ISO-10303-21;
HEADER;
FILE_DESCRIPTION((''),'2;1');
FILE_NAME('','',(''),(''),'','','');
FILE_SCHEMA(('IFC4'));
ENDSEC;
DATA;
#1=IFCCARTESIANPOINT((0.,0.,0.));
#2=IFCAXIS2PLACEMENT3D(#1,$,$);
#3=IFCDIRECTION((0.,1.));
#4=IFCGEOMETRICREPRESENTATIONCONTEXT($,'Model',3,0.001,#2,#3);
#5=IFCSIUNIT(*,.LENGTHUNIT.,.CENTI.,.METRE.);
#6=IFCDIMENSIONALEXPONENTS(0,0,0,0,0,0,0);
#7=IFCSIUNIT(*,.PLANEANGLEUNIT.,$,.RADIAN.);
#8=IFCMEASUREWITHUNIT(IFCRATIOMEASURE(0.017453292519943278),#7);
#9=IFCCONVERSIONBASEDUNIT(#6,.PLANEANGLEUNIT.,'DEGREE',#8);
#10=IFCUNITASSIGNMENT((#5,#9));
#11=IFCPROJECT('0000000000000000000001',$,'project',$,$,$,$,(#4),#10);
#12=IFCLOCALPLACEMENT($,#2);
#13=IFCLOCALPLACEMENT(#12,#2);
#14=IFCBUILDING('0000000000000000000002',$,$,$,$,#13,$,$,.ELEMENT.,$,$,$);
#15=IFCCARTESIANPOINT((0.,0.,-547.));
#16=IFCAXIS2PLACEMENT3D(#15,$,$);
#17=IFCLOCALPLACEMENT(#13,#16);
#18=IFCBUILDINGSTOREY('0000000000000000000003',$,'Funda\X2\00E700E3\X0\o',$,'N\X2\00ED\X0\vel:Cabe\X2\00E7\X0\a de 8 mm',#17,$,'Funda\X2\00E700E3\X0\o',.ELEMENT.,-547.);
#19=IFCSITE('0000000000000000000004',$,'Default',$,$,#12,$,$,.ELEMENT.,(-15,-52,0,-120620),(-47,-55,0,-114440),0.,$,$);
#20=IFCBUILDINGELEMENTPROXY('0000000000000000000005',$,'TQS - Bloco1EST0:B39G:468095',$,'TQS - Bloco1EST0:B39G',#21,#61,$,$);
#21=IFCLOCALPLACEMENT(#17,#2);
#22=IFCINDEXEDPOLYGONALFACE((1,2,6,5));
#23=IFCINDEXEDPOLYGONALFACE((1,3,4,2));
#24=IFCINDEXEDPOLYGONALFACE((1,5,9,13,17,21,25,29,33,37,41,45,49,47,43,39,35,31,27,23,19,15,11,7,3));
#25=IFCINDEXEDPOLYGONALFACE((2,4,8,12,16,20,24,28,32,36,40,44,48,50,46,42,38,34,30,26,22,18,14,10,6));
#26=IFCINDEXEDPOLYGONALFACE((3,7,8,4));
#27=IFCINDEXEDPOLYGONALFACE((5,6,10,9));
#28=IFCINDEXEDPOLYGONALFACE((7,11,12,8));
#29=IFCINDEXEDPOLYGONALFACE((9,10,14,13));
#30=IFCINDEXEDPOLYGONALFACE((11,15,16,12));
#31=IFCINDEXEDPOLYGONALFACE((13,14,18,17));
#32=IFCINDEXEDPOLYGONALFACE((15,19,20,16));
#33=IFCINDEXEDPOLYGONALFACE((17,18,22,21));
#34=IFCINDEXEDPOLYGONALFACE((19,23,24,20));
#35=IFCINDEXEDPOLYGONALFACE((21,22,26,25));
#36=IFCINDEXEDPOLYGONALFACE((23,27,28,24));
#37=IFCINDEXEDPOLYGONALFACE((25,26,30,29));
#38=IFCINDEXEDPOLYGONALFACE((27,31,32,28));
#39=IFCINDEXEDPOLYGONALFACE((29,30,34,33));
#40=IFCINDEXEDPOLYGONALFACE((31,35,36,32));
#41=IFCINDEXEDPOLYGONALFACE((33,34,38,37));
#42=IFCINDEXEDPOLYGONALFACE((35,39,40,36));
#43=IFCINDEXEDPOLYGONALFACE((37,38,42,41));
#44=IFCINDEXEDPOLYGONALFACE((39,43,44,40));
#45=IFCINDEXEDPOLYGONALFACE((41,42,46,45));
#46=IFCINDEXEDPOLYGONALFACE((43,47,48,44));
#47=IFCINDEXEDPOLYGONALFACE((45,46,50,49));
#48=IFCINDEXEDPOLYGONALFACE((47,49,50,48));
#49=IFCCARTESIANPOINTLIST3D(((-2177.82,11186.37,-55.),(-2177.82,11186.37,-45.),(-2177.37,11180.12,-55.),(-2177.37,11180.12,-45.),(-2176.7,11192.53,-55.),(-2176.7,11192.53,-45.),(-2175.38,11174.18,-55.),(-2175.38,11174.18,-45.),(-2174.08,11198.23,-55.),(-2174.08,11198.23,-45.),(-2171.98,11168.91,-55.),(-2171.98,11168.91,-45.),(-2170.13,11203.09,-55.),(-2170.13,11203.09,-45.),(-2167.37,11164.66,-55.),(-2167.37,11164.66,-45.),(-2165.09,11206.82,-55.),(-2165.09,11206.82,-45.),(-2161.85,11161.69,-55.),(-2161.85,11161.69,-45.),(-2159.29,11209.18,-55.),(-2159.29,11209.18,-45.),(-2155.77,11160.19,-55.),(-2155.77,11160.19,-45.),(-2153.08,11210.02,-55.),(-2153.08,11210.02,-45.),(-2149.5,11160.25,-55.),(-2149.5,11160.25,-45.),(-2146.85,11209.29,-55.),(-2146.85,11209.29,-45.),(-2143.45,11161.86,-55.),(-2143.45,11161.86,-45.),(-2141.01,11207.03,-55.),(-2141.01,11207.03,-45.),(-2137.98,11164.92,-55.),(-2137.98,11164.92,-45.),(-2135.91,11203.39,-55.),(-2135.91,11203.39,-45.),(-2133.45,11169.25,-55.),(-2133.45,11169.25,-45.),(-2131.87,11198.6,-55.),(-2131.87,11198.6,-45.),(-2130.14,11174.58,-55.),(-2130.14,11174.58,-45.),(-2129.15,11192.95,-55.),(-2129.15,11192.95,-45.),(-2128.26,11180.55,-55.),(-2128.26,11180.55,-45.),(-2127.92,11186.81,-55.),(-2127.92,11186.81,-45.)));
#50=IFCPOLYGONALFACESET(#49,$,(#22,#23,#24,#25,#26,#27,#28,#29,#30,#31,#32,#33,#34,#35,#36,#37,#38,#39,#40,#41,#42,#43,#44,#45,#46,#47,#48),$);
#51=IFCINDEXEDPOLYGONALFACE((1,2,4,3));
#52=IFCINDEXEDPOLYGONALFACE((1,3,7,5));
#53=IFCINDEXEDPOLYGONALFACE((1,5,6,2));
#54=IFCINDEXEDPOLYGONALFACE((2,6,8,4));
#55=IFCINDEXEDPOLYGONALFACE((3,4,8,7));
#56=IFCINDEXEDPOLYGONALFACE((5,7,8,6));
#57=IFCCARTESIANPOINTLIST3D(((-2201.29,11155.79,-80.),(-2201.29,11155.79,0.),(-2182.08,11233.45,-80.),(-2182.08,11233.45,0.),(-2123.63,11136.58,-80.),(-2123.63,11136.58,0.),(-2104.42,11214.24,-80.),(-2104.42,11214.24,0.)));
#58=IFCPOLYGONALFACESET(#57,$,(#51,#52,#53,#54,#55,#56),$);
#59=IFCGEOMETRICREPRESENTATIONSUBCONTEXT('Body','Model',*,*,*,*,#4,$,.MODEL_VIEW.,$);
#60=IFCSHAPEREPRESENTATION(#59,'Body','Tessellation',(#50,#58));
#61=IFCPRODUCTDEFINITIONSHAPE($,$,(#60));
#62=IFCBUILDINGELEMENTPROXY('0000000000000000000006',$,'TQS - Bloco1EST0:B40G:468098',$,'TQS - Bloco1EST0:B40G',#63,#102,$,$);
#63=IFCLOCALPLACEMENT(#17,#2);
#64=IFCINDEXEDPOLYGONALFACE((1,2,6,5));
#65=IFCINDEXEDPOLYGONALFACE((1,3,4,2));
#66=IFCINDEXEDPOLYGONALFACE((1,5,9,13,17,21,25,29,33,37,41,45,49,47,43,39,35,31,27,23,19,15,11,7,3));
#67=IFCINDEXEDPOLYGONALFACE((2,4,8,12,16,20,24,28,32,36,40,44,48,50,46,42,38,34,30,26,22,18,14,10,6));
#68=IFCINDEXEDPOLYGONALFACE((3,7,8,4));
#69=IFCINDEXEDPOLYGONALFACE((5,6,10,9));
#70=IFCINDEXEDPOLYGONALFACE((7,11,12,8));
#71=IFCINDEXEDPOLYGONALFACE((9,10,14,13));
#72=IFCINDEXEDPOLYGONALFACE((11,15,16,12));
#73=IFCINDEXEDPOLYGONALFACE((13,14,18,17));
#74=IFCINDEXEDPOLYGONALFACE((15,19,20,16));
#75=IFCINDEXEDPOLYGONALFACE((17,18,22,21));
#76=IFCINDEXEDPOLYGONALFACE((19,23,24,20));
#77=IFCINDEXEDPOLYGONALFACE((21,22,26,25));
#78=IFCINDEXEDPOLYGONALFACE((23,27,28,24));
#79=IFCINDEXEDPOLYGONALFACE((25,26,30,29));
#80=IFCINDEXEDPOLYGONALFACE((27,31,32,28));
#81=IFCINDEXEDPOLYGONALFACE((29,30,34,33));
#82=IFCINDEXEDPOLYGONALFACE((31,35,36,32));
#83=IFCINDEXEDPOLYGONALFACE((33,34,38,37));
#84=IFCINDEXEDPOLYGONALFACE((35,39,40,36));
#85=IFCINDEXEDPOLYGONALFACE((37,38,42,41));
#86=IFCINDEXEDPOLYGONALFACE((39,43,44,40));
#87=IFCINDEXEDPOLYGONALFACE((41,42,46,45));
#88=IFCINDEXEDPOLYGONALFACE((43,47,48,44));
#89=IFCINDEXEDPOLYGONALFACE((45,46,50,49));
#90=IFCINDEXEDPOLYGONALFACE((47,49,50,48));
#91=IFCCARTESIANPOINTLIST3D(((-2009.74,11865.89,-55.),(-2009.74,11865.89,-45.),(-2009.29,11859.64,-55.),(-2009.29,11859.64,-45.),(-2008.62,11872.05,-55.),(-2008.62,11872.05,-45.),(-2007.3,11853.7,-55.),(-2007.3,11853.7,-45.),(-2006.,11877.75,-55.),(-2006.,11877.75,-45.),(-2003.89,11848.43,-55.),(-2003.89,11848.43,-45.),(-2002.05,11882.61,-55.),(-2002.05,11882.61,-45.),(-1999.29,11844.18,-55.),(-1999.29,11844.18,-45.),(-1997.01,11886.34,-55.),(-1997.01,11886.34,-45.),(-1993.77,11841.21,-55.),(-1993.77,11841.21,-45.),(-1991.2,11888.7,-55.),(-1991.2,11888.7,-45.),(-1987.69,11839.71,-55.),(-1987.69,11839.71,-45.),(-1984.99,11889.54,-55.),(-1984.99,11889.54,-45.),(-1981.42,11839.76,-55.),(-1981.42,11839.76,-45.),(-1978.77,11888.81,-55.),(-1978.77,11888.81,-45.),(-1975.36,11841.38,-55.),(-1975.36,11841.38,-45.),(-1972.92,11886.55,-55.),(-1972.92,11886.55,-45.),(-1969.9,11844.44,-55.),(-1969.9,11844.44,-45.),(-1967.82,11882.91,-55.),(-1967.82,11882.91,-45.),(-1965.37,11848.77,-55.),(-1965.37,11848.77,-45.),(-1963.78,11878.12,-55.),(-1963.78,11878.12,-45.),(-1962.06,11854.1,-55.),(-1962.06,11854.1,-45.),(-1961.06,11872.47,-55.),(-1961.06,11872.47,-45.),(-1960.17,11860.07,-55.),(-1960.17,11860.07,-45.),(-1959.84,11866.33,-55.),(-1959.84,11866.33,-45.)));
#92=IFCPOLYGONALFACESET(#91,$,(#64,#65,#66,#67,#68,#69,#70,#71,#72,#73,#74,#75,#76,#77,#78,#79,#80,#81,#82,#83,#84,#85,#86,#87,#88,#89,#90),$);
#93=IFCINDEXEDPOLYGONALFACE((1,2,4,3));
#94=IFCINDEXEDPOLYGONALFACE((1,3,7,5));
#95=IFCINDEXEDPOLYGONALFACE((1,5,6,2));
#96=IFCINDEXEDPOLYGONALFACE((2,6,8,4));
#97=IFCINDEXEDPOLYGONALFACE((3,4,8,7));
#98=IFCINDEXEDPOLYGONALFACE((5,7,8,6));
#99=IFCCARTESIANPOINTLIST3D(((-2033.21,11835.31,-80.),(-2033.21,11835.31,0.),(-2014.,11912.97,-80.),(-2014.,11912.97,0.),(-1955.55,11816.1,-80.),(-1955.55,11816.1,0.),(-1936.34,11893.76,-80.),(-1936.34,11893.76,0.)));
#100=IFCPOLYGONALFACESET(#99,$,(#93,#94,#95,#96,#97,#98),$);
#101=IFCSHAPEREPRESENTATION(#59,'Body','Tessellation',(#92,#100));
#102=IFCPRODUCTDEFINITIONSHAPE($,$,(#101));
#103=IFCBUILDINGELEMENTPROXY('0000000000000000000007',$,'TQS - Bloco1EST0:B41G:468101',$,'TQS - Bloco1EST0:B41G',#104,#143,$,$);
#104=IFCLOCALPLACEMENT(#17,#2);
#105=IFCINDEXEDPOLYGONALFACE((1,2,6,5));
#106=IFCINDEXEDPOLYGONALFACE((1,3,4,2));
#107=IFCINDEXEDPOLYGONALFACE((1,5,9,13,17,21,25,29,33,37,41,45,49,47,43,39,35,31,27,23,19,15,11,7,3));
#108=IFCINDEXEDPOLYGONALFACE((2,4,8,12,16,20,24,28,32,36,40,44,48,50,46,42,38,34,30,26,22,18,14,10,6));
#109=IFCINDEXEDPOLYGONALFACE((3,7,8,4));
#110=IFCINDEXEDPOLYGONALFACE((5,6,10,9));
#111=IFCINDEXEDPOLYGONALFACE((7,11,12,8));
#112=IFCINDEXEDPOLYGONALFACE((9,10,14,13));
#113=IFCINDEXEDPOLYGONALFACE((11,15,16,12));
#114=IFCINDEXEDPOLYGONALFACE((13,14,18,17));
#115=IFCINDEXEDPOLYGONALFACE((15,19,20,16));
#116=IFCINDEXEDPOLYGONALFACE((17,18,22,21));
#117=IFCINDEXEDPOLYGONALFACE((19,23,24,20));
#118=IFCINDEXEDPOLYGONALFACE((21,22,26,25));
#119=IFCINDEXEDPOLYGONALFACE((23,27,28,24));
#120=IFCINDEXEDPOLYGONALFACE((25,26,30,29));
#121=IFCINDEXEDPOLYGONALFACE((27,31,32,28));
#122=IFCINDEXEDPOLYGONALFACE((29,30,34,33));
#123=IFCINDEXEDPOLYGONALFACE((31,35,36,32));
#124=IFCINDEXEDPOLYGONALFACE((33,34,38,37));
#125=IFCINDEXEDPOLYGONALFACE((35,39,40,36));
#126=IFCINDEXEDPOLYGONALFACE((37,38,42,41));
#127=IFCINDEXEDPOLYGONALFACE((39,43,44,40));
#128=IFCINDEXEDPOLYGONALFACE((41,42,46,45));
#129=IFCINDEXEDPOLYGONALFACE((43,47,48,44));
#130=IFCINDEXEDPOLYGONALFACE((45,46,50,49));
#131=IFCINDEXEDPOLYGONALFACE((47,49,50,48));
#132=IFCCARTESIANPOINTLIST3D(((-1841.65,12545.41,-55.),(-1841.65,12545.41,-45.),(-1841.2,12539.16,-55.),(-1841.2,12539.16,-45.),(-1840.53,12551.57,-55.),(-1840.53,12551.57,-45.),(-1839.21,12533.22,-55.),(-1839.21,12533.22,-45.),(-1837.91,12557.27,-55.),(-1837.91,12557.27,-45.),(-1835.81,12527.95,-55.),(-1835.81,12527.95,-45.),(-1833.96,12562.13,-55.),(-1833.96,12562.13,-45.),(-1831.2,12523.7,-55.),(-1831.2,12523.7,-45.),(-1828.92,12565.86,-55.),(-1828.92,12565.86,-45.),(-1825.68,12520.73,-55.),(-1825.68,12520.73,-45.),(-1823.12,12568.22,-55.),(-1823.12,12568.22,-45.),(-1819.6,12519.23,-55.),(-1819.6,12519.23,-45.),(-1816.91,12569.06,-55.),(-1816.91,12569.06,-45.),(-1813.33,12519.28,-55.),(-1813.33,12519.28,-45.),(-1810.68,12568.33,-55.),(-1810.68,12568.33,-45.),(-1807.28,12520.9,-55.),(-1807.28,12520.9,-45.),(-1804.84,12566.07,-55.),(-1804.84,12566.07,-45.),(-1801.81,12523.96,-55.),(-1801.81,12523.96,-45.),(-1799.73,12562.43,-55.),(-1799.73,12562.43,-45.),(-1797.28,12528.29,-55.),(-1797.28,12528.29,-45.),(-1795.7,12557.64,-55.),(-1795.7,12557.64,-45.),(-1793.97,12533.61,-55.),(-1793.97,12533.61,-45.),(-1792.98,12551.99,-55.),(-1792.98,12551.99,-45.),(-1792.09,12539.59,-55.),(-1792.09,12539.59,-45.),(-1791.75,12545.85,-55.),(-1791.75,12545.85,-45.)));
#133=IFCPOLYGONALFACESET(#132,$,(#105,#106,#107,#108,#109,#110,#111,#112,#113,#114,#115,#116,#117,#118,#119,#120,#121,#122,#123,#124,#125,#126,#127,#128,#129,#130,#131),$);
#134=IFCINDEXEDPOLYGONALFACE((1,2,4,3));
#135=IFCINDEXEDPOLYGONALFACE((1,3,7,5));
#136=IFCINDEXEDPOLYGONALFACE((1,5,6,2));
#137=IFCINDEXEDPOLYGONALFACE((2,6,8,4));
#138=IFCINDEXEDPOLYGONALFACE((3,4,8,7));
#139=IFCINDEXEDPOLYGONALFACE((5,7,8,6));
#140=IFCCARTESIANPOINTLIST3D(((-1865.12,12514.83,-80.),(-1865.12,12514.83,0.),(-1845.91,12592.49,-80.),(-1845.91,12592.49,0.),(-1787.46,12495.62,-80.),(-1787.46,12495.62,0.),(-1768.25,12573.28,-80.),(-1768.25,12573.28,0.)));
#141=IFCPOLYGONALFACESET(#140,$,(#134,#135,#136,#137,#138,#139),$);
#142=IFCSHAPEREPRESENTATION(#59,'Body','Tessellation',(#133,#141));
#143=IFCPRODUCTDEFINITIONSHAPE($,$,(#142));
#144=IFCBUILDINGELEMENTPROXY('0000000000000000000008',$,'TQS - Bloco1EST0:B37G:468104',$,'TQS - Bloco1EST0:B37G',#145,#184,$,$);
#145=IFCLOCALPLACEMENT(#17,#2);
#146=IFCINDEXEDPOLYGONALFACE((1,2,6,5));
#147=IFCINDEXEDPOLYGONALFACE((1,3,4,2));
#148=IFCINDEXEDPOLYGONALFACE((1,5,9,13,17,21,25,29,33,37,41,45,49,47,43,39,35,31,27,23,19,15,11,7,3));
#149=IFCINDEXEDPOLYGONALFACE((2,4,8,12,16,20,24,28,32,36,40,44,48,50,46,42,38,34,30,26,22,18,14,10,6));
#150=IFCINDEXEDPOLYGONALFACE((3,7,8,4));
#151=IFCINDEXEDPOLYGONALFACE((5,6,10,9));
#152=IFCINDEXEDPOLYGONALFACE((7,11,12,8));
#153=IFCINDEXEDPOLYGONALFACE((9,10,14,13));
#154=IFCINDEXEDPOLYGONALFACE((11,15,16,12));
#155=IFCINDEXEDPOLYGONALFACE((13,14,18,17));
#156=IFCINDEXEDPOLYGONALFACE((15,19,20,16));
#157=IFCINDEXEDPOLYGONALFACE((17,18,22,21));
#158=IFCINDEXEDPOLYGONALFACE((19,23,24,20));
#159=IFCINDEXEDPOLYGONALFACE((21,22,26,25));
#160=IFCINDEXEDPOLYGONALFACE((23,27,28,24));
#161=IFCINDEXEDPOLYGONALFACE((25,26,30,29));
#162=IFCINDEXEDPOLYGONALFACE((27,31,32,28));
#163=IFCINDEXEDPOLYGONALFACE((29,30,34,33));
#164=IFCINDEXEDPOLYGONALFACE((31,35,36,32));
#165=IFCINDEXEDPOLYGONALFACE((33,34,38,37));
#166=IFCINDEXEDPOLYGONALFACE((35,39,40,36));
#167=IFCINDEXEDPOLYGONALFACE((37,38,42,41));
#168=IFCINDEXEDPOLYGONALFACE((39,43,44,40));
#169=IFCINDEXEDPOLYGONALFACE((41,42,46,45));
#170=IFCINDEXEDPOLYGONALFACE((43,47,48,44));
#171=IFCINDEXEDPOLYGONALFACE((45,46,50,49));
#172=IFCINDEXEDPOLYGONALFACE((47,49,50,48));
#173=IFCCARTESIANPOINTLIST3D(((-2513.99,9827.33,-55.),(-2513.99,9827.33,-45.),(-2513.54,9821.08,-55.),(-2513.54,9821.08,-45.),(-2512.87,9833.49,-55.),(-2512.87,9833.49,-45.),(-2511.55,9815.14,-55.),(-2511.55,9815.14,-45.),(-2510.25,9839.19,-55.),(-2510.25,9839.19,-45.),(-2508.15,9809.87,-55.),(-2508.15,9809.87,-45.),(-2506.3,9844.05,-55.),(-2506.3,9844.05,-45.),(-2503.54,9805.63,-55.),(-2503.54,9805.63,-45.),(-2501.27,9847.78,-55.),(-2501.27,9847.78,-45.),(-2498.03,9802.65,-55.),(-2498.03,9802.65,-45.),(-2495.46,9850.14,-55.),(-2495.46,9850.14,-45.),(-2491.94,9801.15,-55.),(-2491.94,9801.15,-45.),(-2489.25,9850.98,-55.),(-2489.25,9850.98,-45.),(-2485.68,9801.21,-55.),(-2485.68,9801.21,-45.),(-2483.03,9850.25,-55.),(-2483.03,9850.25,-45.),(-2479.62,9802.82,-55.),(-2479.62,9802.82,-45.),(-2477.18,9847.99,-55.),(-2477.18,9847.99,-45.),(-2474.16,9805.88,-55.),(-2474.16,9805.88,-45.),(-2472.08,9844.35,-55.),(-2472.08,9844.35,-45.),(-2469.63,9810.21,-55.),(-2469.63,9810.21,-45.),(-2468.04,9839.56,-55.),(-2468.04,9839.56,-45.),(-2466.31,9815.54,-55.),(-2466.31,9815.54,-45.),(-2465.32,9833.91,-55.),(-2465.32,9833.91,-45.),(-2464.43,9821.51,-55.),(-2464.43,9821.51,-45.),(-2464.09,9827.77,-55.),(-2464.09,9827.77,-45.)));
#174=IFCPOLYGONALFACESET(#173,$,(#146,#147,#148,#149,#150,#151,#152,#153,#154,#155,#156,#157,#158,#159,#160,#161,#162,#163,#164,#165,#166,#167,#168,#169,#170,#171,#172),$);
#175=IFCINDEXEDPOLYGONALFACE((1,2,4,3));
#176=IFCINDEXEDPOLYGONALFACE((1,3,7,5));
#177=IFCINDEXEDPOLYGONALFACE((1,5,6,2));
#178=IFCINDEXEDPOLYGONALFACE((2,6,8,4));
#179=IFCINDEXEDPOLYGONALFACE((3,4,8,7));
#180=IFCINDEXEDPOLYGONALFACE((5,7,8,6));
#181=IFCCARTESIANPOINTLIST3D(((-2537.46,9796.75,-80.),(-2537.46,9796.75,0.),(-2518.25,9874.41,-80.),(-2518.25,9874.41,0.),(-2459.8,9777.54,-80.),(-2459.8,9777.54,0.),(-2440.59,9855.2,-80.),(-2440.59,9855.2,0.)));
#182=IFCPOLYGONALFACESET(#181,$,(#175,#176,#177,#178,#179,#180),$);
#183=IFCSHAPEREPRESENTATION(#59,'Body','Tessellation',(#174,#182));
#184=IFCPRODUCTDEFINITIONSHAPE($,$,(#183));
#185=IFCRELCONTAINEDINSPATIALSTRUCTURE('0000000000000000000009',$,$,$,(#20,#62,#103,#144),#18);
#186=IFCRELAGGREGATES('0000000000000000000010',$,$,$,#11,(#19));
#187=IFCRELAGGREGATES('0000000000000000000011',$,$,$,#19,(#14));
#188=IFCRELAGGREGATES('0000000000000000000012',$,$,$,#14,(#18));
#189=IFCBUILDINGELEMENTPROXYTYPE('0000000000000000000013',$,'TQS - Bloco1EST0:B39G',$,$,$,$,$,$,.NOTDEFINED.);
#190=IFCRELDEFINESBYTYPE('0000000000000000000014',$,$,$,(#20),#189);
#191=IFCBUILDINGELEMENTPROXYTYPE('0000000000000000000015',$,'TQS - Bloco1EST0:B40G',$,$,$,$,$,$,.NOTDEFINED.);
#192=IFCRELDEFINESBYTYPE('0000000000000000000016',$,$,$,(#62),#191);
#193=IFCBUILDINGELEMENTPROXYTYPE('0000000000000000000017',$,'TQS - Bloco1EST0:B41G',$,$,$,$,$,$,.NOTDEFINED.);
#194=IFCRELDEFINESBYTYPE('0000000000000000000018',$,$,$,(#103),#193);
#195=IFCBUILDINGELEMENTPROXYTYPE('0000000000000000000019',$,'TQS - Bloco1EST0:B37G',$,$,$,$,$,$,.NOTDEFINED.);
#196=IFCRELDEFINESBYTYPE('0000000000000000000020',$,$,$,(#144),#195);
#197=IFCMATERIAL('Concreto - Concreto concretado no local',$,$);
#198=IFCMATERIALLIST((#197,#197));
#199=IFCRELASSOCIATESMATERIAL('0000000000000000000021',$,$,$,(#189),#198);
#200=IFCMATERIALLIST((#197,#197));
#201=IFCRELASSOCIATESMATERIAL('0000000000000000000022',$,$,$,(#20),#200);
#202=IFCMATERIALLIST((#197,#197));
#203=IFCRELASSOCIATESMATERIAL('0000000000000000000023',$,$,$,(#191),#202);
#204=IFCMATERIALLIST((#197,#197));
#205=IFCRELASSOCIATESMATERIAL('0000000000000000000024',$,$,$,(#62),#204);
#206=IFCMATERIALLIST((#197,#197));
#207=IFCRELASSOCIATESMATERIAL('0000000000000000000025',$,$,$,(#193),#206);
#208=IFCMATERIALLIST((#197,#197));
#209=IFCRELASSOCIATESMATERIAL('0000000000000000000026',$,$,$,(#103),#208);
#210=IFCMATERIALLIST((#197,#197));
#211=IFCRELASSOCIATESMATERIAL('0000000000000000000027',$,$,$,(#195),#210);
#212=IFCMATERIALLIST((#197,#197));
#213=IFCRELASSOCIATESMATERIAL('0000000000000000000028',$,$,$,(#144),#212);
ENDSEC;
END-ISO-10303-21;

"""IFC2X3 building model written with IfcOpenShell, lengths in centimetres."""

from ifc_helpers import new_model, entity, si_unit, converted_unit, direction, frame, frame_2d, origin, origin_2d_with_axis, place, context, subcontext, project, spatial, rectangle, circle, extrude, source, transform, mapped, material, material_list, type_object, type_shapes, element, save


model = new_model("IFC2X3")

# Units and contexts
model_context = context("Model", 3, precision=0.001, world=origin(), true_north=direction((0.0, 1.0)))
body_context = subcontext(model_context, "Body", "Model", "MODEL_VIEW")
ifc_project = project(units=[si_unit("LENGTHUNIT", "METRE", prefix="CENTI"), converted_unit("PLANEANGLEUNIT", "DEGREE", entity("IfcRatioMeasure", 0.017453292519943278), si_unit("PLANEANGLEUNIT", "RADIAN"), dimensions=[0, 0, 0, 0, 0, 0, 0])], contexts=[model_context])

# Site, building, storey
site_placement = place(None, origin())
site = spatial("IfcSite", under=ifc_project, at=site_placement, Name="Default", CompositionType="ELEMENT", RefLatitude=(-15, -52, 0, -120620), RefLongitude=(-47, -55, 0, -114440), RefElevation=0.0)
building_placement = place(site_placement, origin())
building = spatial("IfcBuilding", under=site, at=building_placement, CompositionType="ELEMENT")
storey_placement = place(building_placement, frame((0.0, 0.0, -547.0)))
storey = spatial("IfcBuildingStorey", under=building, at=storey_placement, Name="Fundação", ObjectType="Nível:Cabeça de 8 mm", LongName="Fundação", CompositionType="ELEMENT", Elevation=-547.0)

# Building element proxies
ifc_material_1 = material(Name="Concreto - Concreto concretado no local")
ifc_material_list_1 = material_list([ifc_material_1, ifc_material_1])
ifc_material_list_2 = material_list([ifc_material_1, ifc_material_1])
building_element_proxy_type_1 = type_object("IfcBuildingElementProxyType", Name="TQS - Bloco1EST0:B39G", PredefinedType="NOTDEFINED", material=ifc_material_list_2)
shared_shape_1 = source(origin(), body_context, "Body", "SweptSolid", [
    extrude(circle(Radius=25.0, at=frame_2d((0.0, 0.0), x_axis=(1.0, 0.0))), frame((0.0, 0.0, -55.0)), (0.0, 0.0, 1.0), 10.0),
    extrude(rectangle(XDim=80.0, YDim=80.0, at=origin_2d_with_axis()), frame((0.0, 0.0, -80.0), z_axis=(0.0, 0.0, 1.0), x_axis=(-1.0, 0.0, 0.0)), (0.0, 0.0, 1.0), 80.0),
])
type_shapes(building_element_proxy_type_1, [shared_shape_1])
proxy_1_placement = place(storey_placement, frame((-2152.86, 11185.02, 0.0), z_axis=(0.0, 0.0, 1.0), x_axis=(0.240122, 0.970743, 0.0)))
element("IfcBuildingElementProxy", 1, at=proxy_1_placement, inside=storey, type_object=building_element_proxy_type_1, material=ifc_material_list_1, Name="TQS - Bloco1EST0:B39G:468095", ObjectType="TQS - Bloco1EST0:B39G", context=body_context, shape_type="MappedRepresentation", body=[
    mapped(shared_shape_1, transform((0.0, 0.0, 0.0), scale=1.0)),
])
ifc_material_list_3 = material_list([ifc_material_1, ifc_material_1])
ifc_material_list_4 = material_list([ifc_material_1, ifc_material_1])
building_element_proxy_type_2 = type_object("IfcBuildingElementProxyType", Name="TQS - Bloco1EST0:B40G", PredefinedType="NOTDEFINED", material=ifc_material_list_4)
shared_shape_2 = source(origin(), body_context, "Body", "SweptSolid", [
    extrude(circle(Radius=25.0, at=frame_2d((0.0, 0.0), x_axis=(1.0, 0.0))), frame((0.0, 0.0, -55.0)), (0.0, 0.0, 1.0), 10.0),
    extrude(rectangle(XDim=80.0, YDim=80.0, at=origin_2d_with_axis()), frame((0.0, 0.0, -80.0), z_axis=(0.0, 0.0, 1.0), x_axis=(-1.0, 0.0, 0.0)), (0.0, 0.0, 1.0), 80.0),
])
type_shapes(building_element_proxy_type_2, [shared_shape_2])
proxy_2_placement = place(storey_placement, frame((-1984.77, 11864.54, 0.0), z_axis=(0.0, 0.0, 1.0), x_axis=(0.240122, 0.970743, 0.0)))
element("IfcBuildingElementProxy", 2, at=proxy_2_placement, inside=storey, type_object=building_element_proxy_type_2, material=ifc_material_list_3, Name="TQS - Bloco1EST0:B40G:468098", ObjectType="TQS - Bloco1EST0:B40G", context=body_context, shape_type="MappedRepresentation", body=[
    mapped(shared_shape_2, transform((0.0, 0.0, 0.0), scale=1.0)),
])
ifc_material_list_5 = material_list([ifc_material_1, ifc_material_1])
ifc_material_list_6 = material_list([ifc_material_1, ifc_material_1])
building_element_proxy_type_3 = type_object("IfcBuildingElementProxyType", Name="TQS - Bloco1EST0:B41G", PredefinedType="NOTDEFINED", material=ifc_material_list_6)
shared_shape_3 = source(origin(), body_context, "Body", "SweptSolid", [
    extrude(circle(Radius=25.0, at=frame_2d((0.0, 0.0), x_axis=(1.0, 0.0))), frame((0.0, 0.0, -55.0)), (0.0, 0.0, 1.0), 10.0),
    extrude(rectangle(XDim=80.0, YDim=80.0, at=origin_2d_with_axis()), frame((0.0, 0.0, -80.0), z_axis=(0.0, 0.0, 1.0), x_axis=(-1.0, 0.0, 0.0)), (0.0, 0.0, 1.0), 80.0),
])
type_shapes(building_element_proxy_type_3, [shared_shape_3])
proxy_3_placement = place(storey_placement, frame((-1816.69, 12544.06, 0.0), z_axis=(0.0, 0.0, 1.0), x_axis=(0.240122, 0.970743, 0.0)))
element("IfcBuildingElementProxy", 3, at=proxy_3_placement, inside=storey, type_object=building_element_proxy_type_3, material=ifc_material_list_5, Name="TQS - Bloco1EST0:B41G:468101", ObjectType="TQS - Bloco1EST0:B41G", context=body_context, shape_type="MappedRepresentation", body=[
    mapped(shared_shape_3, transform((0.0, 0.0, 0.0), scale=1.0)),
])
ifc_material_list_7 = material_list([ifc_material_1, ifc_material_1])
ifc_material_list_8 = material_list([ifc_material_1, ifc_material_1])
building_element_proxy_type_4 = type_object("IfcBuildingElementProxyType", Name="TQS - Bloco1EST0:B37G", PredefinedType="NOTDEFINED", material=ifc_material_list_8)
shared_shape_4 = source(origin(), body_context, "Body", "SweptSolid", [
    extrude(circle(Radius=25.0, at=frame_2d((0.0, 0.0), x_axis=(1.0, 0.0))), frame((0.0, 0.0, -55.0)), (0.0, 0.0, 1.0), 10.0),
    extrude(rectangle(XDim=80.0, YDim=80.0, at=origin_2d_with_axis()), frame((0.0, 0.0, -80.0), z_axis=(0.0, 0.0, 1.0), x_axis=(-1.0, 0.0, 0.0)), (0.0, 0.0, 1.0), 80.0),
])
type_shapes(building_element_proxy_type_4, [shared_shape_4])
proxy_4_placement = place(storey_placement, frame((-2489.03, 9825.98, 0.0), z_axis=(0.0, 0.0, 1.0), x_axis=(0.240122, 0.970743, 0.0)))
element("IfcBuildingElementProxy", 4, at=proxy_4_placement, inside=storey, type_object=building_element_proxy_type_4, material=ifc_material_list_7, Name="TQS - Bloco1EST0:B37G:468104", ObjectType="TQS - Bloco1EST0:B37G", context=body_context, shape_type="MappedRepresentation", body=[
    mapped(shared_shape_4, transform((0.0, 0.0, 0.0), scale=1.0)),
])

save(model, "model.ifc")
